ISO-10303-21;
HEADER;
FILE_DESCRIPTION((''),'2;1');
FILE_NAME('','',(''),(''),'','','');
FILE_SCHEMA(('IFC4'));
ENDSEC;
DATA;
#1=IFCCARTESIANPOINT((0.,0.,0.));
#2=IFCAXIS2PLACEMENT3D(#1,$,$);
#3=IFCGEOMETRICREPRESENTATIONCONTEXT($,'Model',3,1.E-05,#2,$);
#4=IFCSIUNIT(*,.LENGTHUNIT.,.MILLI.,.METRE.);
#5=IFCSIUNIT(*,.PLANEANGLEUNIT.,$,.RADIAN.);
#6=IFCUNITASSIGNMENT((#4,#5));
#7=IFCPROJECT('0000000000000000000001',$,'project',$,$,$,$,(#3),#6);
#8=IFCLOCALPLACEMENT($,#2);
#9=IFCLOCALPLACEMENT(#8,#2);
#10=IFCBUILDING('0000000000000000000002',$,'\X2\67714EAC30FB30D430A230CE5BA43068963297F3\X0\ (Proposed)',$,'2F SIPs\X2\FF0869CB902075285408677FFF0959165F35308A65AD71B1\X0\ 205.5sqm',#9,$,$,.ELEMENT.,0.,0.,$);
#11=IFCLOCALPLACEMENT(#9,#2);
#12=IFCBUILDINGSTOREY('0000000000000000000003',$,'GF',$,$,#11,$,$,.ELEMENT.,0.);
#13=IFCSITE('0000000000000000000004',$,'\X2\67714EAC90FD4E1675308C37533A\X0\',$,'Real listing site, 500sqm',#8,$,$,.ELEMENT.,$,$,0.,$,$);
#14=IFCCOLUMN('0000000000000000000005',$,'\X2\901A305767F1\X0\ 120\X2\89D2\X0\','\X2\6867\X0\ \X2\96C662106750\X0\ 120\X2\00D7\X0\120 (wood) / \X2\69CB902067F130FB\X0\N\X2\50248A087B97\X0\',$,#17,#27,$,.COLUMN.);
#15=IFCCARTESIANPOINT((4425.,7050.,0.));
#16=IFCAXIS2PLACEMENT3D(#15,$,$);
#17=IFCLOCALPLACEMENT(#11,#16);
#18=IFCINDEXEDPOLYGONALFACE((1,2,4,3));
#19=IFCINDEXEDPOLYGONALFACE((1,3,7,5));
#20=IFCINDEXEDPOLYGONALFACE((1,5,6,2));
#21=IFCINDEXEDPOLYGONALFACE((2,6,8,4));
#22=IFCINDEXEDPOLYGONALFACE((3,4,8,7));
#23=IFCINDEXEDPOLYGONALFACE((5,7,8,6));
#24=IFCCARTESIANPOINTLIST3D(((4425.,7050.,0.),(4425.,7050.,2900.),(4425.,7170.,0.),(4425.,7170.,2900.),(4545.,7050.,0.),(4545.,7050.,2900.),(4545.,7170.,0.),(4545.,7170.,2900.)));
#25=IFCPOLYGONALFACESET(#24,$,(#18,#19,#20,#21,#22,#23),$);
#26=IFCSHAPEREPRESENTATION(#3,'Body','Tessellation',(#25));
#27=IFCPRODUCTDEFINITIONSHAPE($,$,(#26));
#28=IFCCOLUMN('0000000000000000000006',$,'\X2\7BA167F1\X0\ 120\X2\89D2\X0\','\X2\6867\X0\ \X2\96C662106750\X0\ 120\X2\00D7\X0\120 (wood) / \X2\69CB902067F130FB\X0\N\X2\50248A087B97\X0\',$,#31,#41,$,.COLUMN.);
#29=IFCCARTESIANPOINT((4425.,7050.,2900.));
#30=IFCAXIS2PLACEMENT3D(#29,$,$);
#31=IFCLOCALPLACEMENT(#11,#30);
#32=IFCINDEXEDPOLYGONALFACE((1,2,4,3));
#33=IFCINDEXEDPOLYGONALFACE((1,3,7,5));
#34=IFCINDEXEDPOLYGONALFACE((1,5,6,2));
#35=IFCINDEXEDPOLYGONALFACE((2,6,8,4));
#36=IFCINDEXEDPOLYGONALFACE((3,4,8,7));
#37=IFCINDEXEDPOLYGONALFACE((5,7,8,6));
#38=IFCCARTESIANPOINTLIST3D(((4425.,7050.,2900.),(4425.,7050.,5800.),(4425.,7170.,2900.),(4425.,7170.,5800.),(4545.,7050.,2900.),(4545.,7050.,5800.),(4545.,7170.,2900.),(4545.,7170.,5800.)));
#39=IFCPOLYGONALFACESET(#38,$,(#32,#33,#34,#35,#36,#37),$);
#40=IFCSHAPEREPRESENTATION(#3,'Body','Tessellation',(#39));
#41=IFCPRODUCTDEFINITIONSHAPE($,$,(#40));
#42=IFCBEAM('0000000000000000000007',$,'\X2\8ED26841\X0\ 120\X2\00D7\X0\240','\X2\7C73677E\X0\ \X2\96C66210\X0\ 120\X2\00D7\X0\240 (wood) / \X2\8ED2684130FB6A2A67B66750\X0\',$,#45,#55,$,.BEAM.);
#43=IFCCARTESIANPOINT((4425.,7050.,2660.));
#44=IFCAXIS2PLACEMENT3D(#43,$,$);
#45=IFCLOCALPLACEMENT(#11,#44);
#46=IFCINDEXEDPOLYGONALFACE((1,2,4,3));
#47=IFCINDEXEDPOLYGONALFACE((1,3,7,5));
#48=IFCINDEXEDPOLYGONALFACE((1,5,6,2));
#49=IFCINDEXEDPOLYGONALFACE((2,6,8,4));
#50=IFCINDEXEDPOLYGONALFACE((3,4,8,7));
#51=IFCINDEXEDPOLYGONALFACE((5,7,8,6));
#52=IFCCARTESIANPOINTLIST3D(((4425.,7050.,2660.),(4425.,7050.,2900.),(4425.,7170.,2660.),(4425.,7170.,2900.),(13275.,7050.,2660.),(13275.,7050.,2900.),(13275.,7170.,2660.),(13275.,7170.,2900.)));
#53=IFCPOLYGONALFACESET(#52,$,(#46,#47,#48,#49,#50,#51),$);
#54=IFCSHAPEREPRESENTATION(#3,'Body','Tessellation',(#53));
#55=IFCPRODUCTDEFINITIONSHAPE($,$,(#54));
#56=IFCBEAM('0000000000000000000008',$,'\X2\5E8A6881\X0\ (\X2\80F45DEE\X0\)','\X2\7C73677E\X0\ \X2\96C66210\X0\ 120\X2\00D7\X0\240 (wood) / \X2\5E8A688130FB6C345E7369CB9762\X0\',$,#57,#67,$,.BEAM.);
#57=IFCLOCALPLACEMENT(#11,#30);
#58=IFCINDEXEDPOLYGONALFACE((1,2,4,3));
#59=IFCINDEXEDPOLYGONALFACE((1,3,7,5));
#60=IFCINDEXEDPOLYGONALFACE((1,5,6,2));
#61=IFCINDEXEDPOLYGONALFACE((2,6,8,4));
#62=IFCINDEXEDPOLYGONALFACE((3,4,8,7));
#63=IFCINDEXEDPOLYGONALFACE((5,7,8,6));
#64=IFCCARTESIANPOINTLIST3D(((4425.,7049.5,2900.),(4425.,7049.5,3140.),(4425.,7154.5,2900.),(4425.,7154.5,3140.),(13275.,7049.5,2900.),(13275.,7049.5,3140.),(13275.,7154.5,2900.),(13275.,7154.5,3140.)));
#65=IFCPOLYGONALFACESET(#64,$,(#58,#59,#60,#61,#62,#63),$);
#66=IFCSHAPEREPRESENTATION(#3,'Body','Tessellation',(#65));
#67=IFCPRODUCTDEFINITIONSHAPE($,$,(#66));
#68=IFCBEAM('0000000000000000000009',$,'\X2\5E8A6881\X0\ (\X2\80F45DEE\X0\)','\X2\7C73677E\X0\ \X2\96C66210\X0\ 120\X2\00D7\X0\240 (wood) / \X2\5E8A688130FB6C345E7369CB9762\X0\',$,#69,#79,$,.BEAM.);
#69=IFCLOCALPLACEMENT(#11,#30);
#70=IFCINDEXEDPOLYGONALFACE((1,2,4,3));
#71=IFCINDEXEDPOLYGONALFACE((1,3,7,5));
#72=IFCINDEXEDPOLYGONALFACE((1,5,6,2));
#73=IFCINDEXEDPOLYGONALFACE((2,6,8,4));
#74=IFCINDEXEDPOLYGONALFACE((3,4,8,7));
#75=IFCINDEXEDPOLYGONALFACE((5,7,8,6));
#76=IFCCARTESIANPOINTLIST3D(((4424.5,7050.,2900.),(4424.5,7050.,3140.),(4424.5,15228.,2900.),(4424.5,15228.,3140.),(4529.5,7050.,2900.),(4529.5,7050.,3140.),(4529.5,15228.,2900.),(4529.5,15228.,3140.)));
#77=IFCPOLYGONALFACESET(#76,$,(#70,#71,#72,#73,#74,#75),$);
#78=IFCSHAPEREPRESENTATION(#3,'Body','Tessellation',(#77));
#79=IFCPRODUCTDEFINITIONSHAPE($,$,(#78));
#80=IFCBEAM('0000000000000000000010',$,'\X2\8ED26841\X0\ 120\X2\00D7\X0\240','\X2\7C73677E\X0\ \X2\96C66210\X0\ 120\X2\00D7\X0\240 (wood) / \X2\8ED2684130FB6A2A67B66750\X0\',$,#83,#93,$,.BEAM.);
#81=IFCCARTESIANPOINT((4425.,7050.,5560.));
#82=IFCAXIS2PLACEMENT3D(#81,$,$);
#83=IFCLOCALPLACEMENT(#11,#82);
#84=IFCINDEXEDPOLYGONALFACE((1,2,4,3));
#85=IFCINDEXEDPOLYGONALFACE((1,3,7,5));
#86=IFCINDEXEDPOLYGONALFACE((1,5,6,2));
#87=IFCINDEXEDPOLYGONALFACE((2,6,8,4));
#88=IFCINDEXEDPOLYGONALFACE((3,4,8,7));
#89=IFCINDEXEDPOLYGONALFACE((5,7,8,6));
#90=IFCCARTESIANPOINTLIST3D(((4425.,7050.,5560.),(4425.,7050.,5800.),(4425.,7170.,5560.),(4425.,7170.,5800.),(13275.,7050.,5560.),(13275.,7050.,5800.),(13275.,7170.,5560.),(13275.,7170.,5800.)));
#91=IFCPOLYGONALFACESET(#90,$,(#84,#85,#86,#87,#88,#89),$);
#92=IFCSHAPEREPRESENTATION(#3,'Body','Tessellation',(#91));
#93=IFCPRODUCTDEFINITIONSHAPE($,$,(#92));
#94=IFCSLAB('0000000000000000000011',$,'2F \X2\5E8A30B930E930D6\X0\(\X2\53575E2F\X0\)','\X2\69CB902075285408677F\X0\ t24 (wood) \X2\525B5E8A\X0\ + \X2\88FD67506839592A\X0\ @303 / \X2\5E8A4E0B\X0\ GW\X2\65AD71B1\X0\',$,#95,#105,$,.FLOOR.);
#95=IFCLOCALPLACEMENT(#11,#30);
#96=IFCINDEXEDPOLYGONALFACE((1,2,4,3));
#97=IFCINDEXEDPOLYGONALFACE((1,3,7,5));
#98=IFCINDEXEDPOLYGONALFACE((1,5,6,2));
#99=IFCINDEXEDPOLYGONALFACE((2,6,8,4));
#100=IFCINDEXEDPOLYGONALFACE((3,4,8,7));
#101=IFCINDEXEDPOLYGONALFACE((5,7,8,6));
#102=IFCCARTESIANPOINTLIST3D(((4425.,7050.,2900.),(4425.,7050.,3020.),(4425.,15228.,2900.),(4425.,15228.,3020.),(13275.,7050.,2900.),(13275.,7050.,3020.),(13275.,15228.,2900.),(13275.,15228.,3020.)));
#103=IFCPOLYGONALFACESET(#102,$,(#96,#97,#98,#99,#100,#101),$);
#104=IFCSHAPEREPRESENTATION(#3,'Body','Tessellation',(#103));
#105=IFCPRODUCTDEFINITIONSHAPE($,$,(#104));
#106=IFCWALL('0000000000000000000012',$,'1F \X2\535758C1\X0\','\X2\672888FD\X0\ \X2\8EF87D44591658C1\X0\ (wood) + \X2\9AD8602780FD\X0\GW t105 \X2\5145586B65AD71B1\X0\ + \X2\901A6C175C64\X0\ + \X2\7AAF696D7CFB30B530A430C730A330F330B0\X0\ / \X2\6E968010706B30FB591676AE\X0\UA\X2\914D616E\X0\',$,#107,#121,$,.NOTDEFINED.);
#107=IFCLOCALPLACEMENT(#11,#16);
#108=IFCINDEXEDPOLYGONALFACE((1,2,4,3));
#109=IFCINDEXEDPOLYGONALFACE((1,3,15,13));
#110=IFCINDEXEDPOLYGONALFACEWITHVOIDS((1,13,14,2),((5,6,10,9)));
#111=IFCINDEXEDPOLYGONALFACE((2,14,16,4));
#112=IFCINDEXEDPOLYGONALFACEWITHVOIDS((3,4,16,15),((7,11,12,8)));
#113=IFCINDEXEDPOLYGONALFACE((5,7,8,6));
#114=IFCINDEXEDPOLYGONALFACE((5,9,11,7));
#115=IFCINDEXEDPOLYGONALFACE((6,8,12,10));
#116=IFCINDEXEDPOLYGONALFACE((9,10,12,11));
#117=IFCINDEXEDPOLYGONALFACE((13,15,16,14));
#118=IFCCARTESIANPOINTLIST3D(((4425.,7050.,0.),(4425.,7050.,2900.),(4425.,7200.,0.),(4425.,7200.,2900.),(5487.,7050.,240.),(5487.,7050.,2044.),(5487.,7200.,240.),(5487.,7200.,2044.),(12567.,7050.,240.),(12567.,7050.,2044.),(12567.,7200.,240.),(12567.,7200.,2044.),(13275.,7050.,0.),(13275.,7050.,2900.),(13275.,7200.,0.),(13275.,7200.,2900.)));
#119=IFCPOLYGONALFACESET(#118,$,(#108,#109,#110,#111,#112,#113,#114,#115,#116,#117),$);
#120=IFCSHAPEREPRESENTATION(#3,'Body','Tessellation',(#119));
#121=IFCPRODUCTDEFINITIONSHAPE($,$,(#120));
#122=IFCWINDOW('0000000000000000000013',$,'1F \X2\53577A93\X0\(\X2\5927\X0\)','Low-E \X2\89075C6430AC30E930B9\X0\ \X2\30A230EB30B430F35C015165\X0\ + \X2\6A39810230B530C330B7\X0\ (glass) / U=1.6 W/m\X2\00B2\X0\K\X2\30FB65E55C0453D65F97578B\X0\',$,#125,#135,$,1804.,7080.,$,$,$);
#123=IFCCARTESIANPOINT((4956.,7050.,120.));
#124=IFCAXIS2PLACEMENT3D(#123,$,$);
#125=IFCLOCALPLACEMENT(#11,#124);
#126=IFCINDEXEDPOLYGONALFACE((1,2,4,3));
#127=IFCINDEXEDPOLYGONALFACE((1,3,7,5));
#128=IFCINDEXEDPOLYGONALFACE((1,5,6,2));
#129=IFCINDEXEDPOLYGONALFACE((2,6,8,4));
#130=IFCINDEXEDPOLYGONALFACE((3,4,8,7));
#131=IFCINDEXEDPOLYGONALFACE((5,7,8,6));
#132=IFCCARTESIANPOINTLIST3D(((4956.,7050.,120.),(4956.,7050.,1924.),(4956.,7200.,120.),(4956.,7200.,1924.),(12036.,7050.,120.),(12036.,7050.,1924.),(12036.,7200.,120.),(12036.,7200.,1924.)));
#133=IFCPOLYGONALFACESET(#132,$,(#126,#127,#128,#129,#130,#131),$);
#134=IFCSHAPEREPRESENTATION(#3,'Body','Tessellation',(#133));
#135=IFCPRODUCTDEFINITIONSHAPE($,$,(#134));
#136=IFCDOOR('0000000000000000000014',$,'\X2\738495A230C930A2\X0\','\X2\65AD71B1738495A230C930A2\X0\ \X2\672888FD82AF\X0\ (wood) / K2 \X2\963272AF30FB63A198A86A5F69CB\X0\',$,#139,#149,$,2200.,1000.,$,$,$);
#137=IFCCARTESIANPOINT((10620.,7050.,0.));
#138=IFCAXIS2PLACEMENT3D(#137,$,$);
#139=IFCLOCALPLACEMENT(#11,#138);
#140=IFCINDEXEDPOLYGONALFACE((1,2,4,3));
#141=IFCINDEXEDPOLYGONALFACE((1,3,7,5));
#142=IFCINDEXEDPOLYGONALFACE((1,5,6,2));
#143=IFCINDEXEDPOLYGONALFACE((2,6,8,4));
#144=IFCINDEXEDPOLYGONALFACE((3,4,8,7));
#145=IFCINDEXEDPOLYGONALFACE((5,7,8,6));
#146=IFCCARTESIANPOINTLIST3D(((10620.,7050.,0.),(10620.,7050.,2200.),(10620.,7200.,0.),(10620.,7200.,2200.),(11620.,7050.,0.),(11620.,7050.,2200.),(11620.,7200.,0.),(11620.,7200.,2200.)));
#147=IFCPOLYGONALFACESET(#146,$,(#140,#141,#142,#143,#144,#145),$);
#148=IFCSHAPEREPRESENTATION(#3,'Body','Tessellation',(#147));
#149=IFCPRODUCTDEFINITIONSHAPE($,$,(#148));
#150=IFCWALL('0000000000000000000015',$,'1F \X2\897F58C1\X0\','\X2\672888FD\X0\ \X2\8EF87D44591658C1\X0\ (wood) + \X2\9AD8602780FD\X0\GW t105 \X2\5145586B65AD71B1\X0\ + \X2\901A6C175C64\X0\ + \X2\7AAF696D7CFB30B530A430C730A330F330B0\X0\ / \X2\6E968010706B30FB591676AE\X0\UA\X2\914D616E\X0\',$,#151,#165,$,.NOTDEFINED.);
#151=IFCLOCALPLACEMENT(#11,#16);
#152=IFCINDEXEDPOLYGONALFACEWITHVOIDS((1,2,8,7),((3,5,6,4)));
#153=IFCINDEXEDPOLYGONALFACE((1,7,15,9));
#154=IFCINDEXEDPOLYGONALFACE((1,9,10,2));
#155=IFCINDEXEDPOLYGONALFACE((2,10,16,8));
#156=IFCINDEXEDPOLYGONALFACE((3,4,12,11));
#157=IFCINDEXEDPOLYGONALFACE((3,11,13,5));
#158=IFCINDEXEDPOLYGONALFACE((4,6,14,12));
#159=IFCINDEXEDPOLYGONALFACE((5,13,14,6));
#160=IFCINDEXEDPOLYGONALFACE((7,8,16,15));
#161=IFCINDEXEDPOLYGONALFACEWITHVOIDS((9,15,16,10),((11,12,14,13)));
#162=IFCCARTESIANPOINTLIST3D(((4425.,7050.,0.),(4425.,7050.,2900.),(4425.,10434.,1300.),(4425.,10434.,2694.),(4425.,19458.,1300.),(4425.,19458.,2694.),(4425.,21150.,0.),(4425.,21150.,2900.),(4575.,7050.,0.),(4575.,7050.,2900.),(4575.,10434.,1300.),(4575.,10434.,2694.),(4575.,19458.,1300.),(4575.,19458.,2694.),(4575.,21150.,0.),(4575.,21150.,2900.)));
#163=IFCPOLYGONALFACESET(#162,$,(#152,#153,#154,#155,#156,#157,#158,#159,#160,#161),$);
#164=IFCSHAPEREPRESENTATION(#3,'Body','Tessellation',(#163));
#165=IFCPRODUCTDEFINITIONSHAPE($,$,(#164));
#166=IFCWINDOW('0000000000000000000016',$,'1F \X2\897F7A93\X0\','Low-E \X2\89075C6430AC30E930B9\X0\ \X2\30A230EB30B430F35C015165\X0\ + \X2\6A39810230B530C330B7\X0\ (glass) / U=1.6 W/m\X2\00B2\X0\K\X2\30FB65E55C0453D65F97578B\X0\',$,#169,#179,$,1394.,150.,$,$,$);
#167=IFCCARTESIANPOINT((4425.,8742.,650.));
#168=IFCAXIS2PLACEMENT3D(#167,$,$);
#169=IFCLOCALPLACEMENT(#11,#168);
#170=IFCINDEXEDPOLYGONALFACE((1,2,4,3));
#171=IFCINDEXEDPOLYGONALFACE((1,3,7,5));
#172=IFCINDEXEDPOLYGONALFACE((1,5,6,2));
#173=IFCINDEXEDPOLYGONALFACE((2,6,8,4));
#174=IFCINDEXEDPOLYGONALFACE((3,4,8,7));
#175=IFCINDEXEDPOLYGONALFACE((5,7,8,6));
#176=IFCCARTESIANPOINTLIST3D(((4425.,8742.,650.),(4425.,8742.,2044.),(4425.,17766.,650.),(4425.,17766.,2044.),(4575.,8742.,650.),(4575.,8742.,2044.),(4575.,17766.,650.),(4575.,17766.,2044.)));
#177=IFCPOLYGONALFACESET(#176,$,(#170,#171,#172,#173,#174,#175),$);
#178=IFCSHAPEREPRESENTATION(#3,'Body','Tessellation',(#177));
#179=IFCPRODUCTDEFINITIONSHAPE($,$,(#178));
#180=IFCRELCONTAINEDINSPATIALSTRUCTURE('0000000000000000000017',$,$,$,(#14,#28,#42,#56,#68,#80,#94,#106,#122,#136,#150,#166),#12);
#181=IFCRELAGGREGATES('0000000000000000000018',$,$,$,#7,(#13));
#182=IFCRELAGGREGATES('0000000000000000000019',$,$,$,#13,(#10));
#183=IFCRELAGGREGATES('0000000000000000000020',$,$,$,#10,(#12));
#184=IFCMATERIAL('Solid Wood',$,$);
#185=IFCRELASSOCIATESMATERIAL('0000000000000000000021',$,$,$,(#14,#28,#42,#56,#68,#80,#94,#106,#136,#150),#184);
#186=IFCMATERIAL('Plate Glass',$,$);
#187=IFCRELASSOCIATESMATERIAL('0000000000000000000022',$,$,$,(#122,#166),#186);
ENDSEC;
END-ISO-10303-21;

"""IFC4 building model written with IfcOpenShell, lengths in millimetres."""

from ifc_helpers import new_model, si_unit, frame, frame_2d, origin, place, context, project, spatial, rectangle, extrude, material, element, fill, save


model = new_model("IFC4")

# Units and contexts
model_context = context("Model", 3, precision=1e-05, world=origin())
ifc_project = project(units=[si_unit("LENGTHUNIT", "METRE", prefix="MILLI"), si_unit("PLANEANGLEUNIT", "RADIAN")], contexts=[model_context])

# Site, building, storey
site_placement = place(None, origin())
site = spatial("IfcSite", under=ifc_project, at=site_placement, Name="東京都世田谷区", ObjectType="Real listing site, 500sqm", CompositionType="ELEMENT", RefElevation=0.0)
building_placement = place(site_placement, origin())
building = spatial("IfcBuilding", under=site, at=building_placement, Name="東京・ピアノ室と防音 (Proposed)", ObjectType="2F SIPs（構造用合板）外張り断熱 205.5sqm", CompositionType="ELEMENT", ElevationOfRefHeight=0.0, ElevationOfTerrain=0.0)
storey_placement = place(building_placement, origin())
storey = spatial("IfcBuildingStorey", under=building, at=storey_placement, Name="GF", CompositionType="ELEMENT", Elevation=0.0)

# Columns
ifc_material_1 = material(Name="Solid Wood")
column_1_placement = place(storey_placement, frame((4425.0, 7050.0, 0.0)))
element("IfcColumn", 1, at=column_1_placement, inside=storey, material=ifc_material_1, Name="通し柱 120角", Description="桧 集成材 120×120 (wood) / 構造柱・N値計算", PredefinedType="COLUMN", context=model_context, shape_type="SweptSolid", body=[
    extrude(rectangle(XDim=120.0, YDim=120.0, at=frame_2d((60.0, 60.0))), frame((4425.0, 7050.0, 0.0)), (0.0, 0.0, 1.0), 2900.0),
])
column_2_placement = place(storey_placement, frame((4425.0, 7050.0, 2900.0)))
element("IfcColumn", 2, at=column_2_placement, inside=storey, material=ifc_material_1, Name="管柱 120角", Description="桧 集成材 120×120 (wood) / 構造柱・N値計算", PredefinedType="COLUMN", context=model_context, shape_type="SweptSolid", body=[
    extrude(rectangle(XDim=120.0, YDim=120.0, at=frame_2d((60.0, 60.0))), frame((4425.0, 7050.0, 2900.0)), (0.0, 0.0, 1.0), 2900.0),
])

# Beams
beam_1_placement = place(storey_placement, frame((4425.0, 7050.0, 2660.0)))
element("IfcBeam", 3, at=beam_1_placement, inside=storey, material=ifc_material_1, Name="軒桁 120×240", Description="米松 集成 120×240 (wood) / 軒桁・横架材", PredefinedType="BEAM", context=model_context, shape_type="SweptSolid", body=[
    extrude(rectangle(XDim=8850.0, YDim=120.0, at=frame_2d((4425.0, 60.0))), frame((4425.0, 7050.0, 2660.0)), (0.0, 0.0, 1.0), 240.0),
])
beam_2_placement = place(storey_placement, frame((4425.0, 7050.0, 2900.0)))
element("IfcBeam", 4, at=beam_2_placement, inside=storey, material=ifc_material_1, Name="床梁 (胴差)", Description="米松 集成 120×240 (wood) / 床梁・水平構面", PredefinedType="BEAM", context=model_context, shape_type="SweptSolid", body=[
    extrude(rectangle(XDim=8850.0, YDim=105.0, at=frame_2d((4425.0, 52.0))), frame((4425.0, 7050.0, 2900.0)), (0.0, 0.0, 1.0), 240.0),
])
beam_3_placement = place(storey_placement, frame((4425.0, 7050.0, 2900.0)))
element("IfcBeam", 5, at=beam_3_placement, inside=storey, material=ifc_material_1, Name="床梁 (胴差)", Description="米松 集成 120×240 (wood) / 床梁・水平構面", PredefinedType="BEAM", context=model_context, shape_type="SweptSolid", body=[
    extrude(rectangle(XDim=105.0, YDim=8178.0, at=frame_2d((52.0, 4089.0))), frame((4425.0, 7050.0, 2900.0)), (0.0, 0.0, 1.0), 240.0),
])
beam_4_placement = place(storey_placement, frame((4425.0, 7050.0, 5560.0)))
element("IfcBeam", 6, at=beam_4_placement, inside=storey, material=ifc_material_1, Name="軒桁 120×240", Description="米松 集成 120×240 (wood) / 軒桁・横架材", PredefinedType="BEAM", context=model_context, shape_type="SweptSolid", body=[
    extrude(rectangle(XDim=8850.0, YDim=120.0, at=frame_2d((4425.0, 60.0))), frame((4425.0, 7050.0, 5560.0)), (0.0, 0.0, 1.0), 240.0),
])

# Slab
slab_1_placement = place(storey_placement, frame((4425.0, 7050.0, 2900.0)))
element("IfcSlab", 7, at=slab_1_placement, inside=storey, material=ifc_material_1, Name="2F 床スラブ(南帯)", Description="構造用合板 t24 (wood) 剛床 + 製材根太 @303 / 床下 GW断熱", PredefinedType="FLOOR", context=model_context, shape_type="SweptSolid", body=[
    extrude(rectangle(XDim=8850.0, YDim=8178.0, at=frame_2d((4425.0, 4089.0))), frame((4425.0, 7050.0, 2900.0)), (0.0, 0.0, 1.0), 120.0),
])

# Wall, openings, window, door
wall_1_placement = place(storey_placement, frame((4425.0, 7050.0, 0.0)))
wall_1 = element("IfcWall", 8, at=wall_1_placement, inside=storey, material=ifc_material_1, Name="1F 南壁", Description="木製 軸組外壁 (wood) + 高性能GW t105 充填断熱 + 通気層 + 窯業系サイディング / 準耐火・外皮UA配慮", PredefinedType="NOTDEFINED", context=model_context, shape_type="SweptSolid", body=[
    extrude(rectangle(XDim=8850.0, YDim=150.0, at=frame_2d((4425.0, 75.0))), frame((4425.0, 7050.0, 0.0)), (0.0, 0.0, 1.0), 2900.0),
])
opening_1_placement = place(storey_placement, frame((4956.0, 7050.0, 120.0)))
opening_1 = element("IfcOpeningElement", 9, at=opening_1_placement, cuts=wall_1, PredefinedType="NOTDEFINED", context=model_context, shape_type="SweptSolid", body=[
    extrude(rectangle(XDim=7080.0, YDim=150.0, at=frame_2d((3540.0, 75.0))), frame((4956.0, 7050.0, 120.0)), (0.0, 0.0, 1.0), 1804.0),
])
opening_2_placement = place(storey_placement, frame((10620.0, 7050.0, 0.0)))
opening_2 = element("IfcOpeningElement", 10, at=opening_2_placement, cuts=wall_1, PredefinedType="NOTDEFINED", context=model_context, shape_type="SweptSolid", body=[
    extrude(rectangle(XDim=1000.0, YDim=150.0, at=frame_2d((500.0, 75.0))), frame((10620.0, 7050.0, 0.0)), (0.0, 0.0, 1.0), 2200.0),
])
ifc_material_2 = material(Name="Plate Glass")
window_1_placement = place(storey_placement, frame((4956.0, 7050.0, 120.0)))
window_1 = element("IfcWindow", 11, at=window_1_placement, inside=storey, material=ifc_material_2, Name="1F 南窓(大)", Description="Low-E 複層ガラス アルゴン封入 + 樹脂サッシ (glass) / U=1.6 W/m²K・日射取得型", OverallHeight=1804.0, OverallWidth=7080.0, context=model_context, shape_type="SweptSolid", body=[
    extrude(rectangle(XDim=7080.0, YDim=150.0, at=frame_2d((3540.0, 75.0))), frame((4956.0, 7050.0, 120.0)), (0.0, 0.0, 1.0), 1804.0),
])
fill(opening_1, window_1)
door_placement = place(storey_placement, frame((10620.0, 7050.0, 0.0)))
door = element("IfcDoor", 12, at=door_placement, inside=storey, material=ifc_material_1, Name="玄関ドア", Description="断熱玄関ドア 木製芯 (wood) / K2 防犯・採風機構", OverallHeight=2200.0, OverallWidth=1000.0, context=model_context, shape_type="SweptSolid", body=[
    extrude(rectangle(XDim=1000.0, YDim=150.0, at=frame_2d((500.0, 75.0))), frame((10620.0, 7050.0, 0.0)), (0.0, 0.0, 1.0), 2200.0),
])
fill(opening_2, door)

# Wall, opening, window
wall_2_placement = place(storey_placement, frame((4425.0, 7050.0, 0.0)))
wall_2 = element("IfcWall", 13, at=wall_2_placement, inside=storey, material=ifc_material_1, Name="1F 西壁", Description="木製 軸組外壁 (wood) + 高性能GW t105 充填断熱 + 通気層 + 窯業系サイディング / 準耐火・外皮UA配慮", PredefinedType="NOTDEFINED", context=model_context, shape_type="SweptSolid", body=[
    extrude(rectangle(XDim=150.0, YDim=14100.0, at=frame_2d((75.0, 7050.0))), frame((4425.0, 7050.0, 0.0)), (0.0, 0.0, 1.0), 2900.0),
])
opening_3_placement = place(storey_placement, frame((4425.0, 8742.0, 650.0)))
opening_3 = element("IfcOpeningElement", 14, at=opening_3_placement, cuts=wall_2, PredefinedType="NOTDEFINED", context=model_context, shape_type="SweptSolid", body=[
    extrude(rectangle(XDim=150.0, YDim=9024.0, at=frame_2d((75.0, 4512.0))), frame((4425.0, 8742.0, 650.0)), (0.0, 0.0, 1.0), 1394.0),
])
window_2_placement = place(storey_placement, frame((4425.0, 8742.0, 650.0)))
window_2 = element("IfcWindow", 15, at=window_2_placement, inside=storey, material=ifc_material_2, Name="1F 西窓", Description="Low-E 複層ガラス アルゴン封入 + 樹脂サッシ (glass) / U=1.6 W/m²K・日射取得型", OverallHeight=1394.0, OverallWidth=150.0, context=model_context, shape_type="SweptSolid", body=[
    extrude(rectangle(XDim=150.0, YDim=9024.0, at=frame_2d((75.0, 4512.0))), frame((4425.0, 8742.0, 650.0)), (0.0, 0.0, 1.0), 1394.0),
])
fill(opening_3, window_2)

save(model, "model.ifc")
